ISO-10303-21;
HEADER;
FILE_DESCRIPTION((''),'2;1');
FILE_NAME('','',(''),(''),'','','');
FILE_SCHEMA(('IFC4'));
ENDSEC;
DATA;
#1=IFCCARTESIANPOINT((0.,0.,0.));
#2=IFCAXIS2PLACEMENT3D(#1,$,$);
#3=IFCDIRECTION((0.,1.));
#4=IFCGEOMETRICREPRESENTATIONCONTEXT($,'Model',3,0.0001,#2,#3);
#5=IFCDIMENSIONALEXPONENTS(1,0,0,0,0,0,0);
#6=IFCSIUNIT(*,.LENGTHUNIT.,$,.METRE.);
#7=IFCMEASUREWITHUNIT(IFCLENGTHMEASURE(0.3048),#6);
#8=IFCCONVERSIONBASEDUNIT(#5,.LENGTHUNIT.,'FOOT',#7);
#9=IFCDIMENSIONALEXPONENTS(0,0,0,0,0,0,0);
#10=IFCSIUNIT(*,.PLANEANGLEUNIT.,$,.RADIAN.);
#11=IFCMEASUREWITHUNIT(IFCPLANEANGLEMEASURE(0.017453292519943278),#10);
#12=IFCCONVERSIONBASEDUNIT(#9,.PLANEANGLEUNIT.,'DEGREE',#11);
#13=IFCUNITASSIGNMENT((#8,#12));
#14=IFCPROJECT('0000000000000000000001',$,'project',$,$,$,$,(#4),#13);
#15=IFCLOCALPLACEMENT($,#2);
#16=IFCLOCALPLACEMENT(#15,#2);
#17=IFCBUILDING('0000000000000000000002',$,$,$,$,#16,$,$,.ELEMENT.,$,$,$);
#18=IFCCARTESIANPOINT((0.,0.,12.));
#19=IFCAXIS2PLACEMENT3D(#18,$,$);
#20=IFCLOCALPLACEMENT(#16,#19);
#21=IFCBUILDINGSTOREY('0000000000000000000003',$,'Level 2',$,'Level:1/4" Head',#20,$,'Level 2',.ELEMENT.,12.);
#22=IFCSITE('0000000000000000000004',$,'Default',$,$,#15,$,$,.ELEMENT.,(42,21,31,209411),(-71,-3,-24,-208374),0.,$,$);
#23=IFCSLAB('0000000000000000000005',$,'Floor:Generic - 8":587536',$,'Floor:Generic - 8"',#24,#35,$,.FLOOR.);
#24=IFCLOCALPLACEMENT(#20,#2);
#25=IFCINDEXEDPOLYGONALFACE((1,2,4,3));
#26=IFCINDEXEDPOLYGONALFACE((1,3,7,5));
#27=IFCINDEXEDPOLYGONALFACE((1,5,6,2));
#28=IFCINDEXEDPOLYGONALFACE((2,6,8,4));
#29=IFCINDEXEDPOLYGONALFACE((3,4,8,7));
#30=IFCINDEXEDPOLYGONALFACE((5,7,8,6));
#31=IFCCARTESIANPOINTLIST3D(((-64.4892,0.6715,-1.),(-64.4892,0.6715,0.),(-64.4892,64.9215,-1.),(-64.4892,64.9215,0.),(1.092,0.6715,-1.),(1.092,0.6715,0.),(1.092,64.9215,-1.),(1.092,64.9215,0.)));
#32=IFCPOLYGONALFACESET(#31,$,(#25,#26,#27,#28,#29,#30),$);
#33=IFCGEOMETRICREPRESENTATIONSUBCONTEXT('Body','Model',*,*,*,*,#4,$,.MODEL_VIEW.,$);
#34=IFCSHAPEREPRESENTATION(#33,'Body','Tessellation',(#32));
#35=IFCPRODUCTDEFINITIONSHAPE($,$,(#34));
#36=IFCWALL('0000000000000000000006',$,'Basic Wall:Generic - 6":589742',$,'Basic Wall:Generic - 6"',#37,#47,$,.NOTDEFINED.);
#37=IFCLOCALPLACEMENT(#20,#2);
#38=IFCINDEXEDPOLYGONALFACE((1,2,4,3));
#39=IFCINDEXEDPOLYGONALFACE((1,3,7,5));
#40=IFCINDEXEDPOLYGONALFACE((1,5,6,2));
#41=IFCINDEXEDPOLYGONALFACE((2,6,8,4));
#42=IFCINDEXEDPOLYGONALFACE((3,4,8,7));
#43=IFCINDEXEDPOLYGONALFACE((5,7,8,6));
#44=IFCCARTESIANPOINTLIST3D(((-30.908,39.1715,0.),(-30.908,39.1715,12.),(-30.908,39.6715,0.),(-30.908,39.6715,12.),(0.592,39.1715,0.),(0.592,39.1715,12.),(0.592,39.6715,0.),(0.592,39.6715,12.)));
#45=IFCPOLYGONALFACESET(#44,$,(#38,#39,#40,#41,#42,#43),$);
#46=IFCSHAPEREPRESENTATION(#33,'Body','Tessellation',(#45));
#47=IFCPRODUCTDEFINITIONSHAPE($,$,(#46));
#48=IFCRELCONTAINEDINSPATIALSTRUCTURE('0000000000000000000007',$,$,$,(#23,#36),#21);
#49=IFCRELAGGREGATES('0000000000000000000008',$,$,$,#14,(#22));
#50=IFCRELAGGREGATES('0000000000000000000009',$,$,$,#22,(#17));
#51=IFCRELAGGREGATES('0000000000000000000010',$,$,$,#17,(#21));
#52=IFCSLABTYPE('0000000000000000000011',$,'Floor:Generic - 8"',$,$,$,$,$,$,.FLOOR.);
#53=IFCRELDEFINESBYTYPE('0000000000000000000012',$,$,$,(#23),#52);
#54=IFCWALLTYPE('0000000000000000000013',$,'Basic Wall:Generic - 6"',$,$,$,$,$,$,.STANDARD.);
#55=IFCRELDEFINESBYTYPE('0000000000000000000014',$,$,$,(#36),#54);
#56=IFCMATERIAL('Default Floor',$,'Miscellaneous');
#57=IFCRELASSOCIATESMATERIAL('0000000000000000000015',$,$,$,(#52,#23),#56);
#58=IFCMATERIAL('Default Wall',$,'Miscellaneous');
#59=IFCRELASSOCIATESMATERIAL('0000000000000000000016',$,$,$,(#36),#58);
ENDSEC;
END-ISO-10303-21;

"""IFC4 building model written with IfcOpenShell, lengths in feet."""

from ifc_helpers import new_model, entity, si_unit, converted_unit, direction, frame, origin, place, context, subcontext, project, spatial, indexed_curve, outline, extrude, material, type_object, element, save


model = new_model("IFC4")

# Units and contexts
model_context = context("Model", 3, precision=0.0001, world=origin(), true_north=direction((0.0, 1.0)))
body_context = subcontext(model_context, "Body", "Model", "MODEL_VIEW")
ifc_project = project(units=[converted_unit("LENGTHUNIT", "FOOT", entity("IfcLengthMeasure", 0.3048), si_unit("LENGTHUNIT", "METRE"), dimensions=[1, 0, 0, 0, 0, 0, 0]), converted_unit("PLANEANGLEUNIT", "DEGREE", entity("IfcPlaneAngleMeasure", 0.017453292519943278), si_unit("PLANEANGLEUNIT", "RADIAN"), dimensions=[0, 0, 0, 0, 0, 0, 0])], contexts=[model_context])

# Site, building, storey
site_placement = place(None, origin())
site = spatial("IfcSite", under=ifc_project, at=site_placement, Name="Default", CompositionType="ELEMENT", RefLatitude=(42, 21, 31, 209411), RefLongitude=(-71, -3, -24, -208374), RefElevation=0.0)
building_placement = place(site_placement, origin())
building = spatial("IfcBuilding", under=site, at=building_placement, CompositionType="ELEMENT")
storey_placement = place(building_placement, frame((0.0, 0.0, 12.0)))
storey = spatial("IfcBuildingStorey", under=building, at=storey_placement, Name="Level 2", ObjectType="Level:1/4\" Head", LongName="Level 2", CompositionType="ELEMENT", Elevation=12.0)

# Slab
ifc_material_1 = material(Name="Default Floor", Category="Miscellaneous")
slab_type = type_object("IfcSlabType", Name="Floor:Generic - 8\"", PredefinedType="FLOOR", material=ifc_material_1)
slab_placement = place(storey_placement, origin())
element("IfcSlab", 1, at=slab_placement, inside=storey, type_object=slab_type, material=ifc_material_1, Name="Floor:Generic - 8\":587536", ObjectType="Floor:Generic - 8\"", PredefinedType="FLOOR", context=body_context, shape_type="SweptSolid", body=[
    extrude(outline(indexed_curve([(-32.125, -32.7906), (32.125, -32.7906), (32.125, 32.7906), (-32.125, 32.7906), (-32.125, -32.7906)], self_intersect=False)), frame((-31.6986, 32.7965, 0.0), z_axis=(0.0, 0.0, -1.0), x_axis=(0.0, 1.0, 0.0)), (0.0, 0.0, 1.0), 1.0),
])

# Wall
ifc_material_2 = material(Name="Default Wall", Category="Miscellaneous")
wall_type = type_object("IfcWallType", Name="Basic Wall:Generic - 6\"", PredefinedType="STANDARD")
wall_placement = place(storey_placement, frame((-30.908, 39.4215, 0.0)))
element("IfcWall", 2, at=wall_placement, inside=storey, type_object=wall_type, material=ifc_material_2, Name="Basic Wall:Generic - 6\":589742", ObjectType="Basic Wall:Generic - 6\"", PredefinedType="NOTDEFINED", context=body_context, shape_type="SweptSolid", body=[
    extrude(outline(indexed_curve([(31.5, 0.25), (0.0, 0.25), (0.0, -0.25), (31.5, -0.25), (31.5, 0.25)], self_intersect=False)), origin(), (0.0, 0.0, 1.0), 12.0),
])

save(model, "model.ifc")
